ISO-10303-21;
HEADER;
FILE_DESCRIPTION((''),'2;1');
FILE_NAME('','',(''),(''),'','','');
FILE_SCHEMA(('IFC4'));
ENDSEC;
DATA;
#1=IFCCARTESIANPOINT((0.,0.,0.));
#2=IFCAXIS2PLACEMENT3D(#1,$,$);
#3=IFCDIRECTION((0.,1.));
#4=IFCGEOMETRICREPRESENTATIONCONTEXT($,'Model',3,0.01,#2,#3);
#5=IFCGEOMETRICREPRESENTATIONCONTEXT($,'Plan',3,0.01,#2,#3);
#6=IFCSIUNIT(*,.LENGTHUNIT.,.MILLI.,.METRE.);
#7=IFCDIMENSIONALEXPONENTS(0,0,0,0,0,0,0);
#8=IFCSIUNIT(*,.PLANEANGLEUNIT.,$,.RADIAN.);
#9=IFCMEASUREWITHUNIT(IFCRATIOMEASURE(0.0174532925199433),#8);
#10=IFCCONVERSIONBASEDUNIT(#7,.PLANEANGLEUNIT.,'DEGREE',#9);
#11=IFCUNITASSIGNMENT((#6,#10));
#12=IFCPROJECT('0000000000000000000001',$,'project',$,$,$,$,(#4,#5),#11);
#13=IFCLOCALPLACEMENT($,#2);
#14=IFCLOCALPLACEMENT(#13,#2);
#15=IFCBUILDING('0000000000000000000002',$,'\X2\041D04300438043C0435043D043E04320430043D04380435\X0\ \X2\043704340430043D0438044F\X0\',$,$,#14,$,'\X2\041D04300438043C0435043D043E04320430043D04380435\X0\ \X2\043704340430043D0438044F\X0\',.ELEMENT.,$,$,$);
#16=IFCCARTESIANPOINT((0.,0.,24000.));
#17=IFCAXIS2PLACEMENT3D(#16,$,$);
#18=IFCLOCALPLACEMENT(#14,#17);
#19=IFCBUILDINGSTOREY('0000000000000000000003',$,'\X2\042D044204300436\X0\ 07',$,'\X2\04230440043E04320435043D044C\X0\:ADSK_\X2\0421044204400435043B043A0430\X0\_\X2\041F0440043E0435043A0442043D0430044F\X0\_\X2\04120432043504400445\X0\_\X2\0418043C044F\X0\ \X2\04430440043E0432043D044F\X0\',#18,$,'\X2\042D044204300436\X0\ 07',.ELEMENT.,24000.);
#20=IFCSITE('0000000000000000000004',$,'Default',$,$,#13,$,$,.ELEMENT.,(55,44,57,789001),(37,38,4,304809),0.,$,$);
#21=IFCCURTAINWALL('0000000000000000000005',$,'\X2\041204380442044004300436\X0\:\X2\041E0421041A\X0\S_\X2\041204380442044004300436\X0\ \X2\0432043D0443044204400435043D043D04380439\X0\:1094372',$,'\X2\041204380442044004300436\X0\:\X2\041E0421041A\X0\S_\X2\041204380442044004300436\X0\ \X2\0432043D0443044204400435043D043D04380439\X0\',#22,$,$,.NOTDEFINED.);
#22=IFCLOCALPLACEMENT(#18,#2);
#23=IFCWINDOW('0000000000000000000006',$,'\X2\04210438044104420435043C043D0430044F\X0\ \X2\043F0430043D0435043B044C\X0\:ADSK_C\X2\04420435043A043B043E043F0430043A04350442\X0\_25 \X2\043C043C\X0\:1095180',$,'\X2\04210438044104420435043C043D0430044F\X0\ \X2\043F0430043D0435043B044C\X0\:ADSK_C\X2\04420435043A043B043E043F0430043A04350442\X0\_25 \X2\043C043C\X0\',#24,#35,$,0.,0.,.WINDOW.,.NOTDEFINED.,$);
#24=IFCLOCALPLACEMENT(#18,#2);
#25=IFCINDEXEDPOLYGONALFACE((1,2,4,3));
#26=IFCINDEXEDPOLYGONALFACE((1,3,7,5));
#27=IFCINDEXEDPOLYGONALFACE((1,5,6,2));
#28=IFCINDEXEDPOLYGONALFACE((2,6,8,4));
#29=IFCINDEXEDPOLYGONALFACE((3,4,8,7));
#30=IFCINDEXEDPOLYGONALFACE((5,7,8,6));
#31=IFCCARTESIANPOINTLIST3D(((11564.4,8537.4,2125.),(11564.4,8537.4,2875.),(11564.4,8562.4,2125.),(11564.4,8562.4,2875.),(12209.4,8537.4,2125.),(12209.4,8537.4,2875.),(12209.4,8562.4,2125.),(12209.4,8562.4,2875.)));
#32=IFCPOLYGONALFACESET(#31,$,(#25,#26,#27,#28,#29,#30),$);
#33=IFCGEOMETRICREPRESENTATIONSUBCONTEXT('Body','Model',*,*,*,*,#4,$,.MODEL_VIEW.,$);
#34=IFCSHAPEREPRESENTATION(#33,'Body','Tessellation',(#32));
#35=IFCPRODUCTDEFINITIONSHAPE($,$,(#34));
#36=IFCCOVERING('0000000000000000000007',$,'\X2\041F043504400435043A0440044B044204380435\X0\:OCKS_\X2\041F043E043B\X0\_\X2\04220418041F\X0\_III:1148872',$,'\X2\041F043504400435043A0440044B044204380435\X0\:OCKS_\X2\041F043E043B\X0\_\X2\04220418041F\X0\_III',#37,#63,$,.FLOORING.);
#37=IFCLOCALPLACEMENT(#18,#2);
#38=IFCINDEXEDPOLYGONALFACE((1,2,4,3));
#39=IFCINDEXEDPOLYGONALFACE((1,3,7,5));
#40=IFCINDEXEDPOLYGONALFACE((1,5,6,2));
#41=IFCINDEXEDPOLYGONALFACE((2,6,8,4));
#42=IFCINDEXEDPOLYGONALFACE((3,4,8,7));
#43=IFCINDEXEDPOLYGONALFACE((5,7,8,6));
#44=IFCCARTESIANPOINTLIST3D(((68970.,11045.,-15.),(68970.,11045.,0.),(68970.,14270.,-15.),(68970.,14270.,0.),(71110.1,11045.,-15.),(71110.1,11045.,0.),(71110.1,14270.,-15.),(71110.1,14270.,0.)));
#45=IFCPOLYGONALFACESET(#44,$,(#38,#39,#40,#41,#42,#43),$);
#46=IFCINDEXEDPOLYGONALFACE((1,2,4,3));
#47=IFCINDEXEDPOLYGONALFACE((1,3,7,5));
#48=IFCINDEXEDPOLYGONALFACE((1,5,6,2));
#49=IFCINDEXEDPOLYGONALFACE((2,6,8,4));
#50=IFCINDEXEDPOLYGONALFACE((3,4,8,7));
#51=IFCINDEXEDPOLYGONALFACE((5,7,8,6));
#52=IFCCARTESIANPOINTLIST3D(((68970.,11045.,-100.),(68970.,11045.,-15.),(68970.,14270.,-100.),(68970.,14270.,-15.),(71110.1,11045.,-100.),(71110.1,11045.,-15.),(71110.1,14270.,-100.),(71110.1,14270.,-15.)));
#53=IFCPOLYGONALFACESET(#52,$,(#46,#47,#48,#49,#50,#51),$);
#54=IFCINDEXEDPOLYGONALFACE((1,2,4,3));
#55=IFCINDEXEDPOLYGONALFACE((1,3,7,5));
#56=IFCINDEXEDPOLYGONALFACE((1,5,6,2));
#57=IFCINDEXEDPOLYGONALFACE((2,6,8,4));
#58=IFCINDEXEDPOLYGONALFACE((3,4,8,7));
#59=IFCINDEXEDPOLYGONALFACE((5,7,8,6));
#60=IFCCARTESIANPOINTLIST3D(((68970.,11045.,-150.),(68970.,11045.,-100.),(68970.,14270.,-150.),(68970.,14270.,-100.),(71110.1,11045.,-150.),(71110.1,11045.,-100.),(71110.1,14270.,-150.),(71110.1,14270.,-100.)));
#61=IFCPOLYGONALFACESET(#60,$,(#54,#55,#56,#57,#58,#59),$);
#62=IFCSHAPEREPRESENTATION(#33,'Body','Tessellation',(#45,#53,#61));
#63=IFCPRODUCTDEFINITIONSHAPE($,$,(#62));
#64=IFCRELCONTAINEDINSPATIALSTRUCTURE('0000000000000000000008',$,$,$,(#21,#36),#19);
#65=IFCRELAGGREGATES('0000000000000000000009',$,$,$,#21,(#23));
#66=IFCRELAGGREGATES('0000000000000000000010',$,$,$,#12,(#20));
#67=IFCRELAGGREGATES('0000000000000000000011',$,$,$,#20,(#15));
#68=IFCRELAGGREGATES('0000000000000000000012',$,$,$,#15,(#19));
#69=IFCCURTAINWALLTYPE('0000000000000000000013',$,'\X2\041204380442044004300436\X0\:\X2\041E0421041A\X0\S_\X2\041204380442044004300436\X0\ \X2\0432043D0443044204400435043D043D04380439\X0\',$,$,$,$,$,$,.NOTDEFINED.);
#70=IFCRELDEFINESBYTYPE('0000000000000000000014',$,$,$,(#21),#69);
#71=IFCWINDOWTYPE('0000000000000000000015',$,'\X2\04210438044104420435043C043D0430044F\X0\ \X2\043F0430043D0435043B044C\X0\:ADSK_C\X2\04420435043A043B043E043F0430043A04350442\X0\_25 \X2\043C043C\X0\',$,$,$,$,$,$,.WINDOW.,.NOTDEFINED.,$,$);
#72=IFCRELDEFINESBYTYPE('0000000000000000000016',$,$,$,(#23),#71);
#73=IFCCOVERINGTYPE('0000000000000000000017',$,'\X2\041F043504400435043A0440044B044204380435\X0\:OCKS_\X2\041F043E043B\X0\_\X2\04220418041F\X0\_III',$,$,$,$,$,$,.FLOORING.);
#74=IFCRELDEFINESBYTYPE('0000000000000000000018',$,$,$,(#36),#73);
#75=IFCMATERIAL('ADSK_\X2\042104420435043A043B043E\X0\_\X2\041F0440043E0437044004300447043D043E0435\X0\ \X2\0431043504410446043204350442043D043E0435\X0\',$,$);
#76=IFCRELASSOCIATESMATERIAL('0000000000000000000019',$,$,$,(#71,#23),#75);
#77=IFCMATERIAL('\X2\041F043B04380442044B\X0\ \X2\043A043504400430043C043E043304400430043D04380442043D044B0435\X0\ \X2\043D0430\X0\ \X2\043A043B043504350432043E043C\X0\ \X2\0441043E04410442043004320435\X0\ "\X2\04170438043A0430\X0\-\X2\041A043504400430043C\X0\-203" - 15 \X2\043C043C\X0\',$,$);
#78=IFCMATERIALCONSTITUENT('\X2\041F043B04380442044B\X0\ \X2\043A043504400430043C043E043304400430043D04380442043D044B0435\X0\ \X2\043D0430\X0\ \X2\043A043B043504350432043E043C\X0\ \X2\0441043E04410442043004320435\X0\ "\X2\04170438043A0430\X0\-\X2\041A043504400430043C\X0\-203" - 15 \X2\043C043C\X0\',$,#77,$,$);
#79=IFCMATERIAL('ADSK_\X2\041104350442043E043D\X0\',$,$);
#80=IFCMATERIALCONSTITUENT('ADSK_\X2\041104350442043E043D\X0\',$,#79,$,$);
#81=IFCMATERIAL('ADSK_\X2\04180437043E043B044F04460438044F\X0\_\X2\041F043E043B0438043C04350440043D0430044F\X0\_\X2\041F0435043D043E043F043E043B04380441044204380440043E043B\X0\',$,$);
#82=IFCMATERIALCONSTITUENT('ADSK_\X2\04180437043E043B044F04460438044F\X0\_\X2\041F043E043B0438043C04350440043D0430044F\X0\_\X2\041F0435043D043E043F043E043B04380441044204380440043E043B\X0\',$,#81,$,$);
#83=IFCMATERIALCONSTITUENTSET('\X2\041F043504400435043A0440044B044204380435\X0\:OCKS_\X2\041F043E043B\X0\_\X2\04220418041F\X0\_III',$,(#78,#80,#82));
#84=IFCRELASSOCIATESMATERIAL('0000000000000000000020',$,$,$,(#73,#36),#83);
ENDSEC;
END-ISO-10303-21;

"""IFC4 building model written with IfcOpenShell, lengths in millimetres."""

from ifc_helpers import new_model, entity, si_unit, converted_unit, direction, frame, origin, place, context, subcontext, project, spatial, indexed_curve, outline, extrude, source, transform, mapped, material, constituent, constituent_set, type_object, type_shapes, element, aggregate, save


model = new_model("IFC4")

# Units and contexts
model_context = context("Model", 3, precision=0.01, world=origin(), true_north=direction((0.0, 1.0)))
plan_context = context("Plan", 3, precision=0.01, world=origin(), true_north=direction((0.0, 1.0)))
body_context = subcontext(model_context, "Body", "Model", "MODEL_VIEW")
ifc_project = project(units=[si_unit("LENGTHUNIT", "METRE", prefix="MILLI"), converted_unit("PLANEANGLEUNIT", "DEGREE", entity("IfcRatioMeasure", 0.0174532925199433), si_unit("PLANEANGLEUNIT", "RADIAN"), dimensions=[0, 0, 0, 0, 0, 0, 0])], contexts=[model_context, plan_context])

# Site, building, storey
site_placement = place(None, frame((0.0, 0.0, 0.0)))
site = spatial("IfcSite", under=ifc_project, at=site_placement, Name="Default", CompositionType="ELEMENT", RefLatitude=(55, 44, 57, 789001), RefLongitude=(37, 38, 4, 304809), RefElevation=0.0)
building_placement = place(site_placement, origin())
building = spatial("IfcBuilding", under=site, at=building_placement, Name="Наименование здания", LongName="Наименование здания", CompositionType="ELEMENT")
storey_placement = place(building_placement, frame((0.0, 0.0, 24000.0)))
storey = spatial("IfcBuildingStorey", under=building, at=storey_placement, Name="Этаж 07", ObjectType="Уровень:ADSK_Стрелка_Проектная_Вверх_Имя уровня", LongName="Этаж 07", CompositionType="ELEMENT", Elevation=24000.0)

# Curtain wall
curtain_wall_type = type_object("IfcCurtainWallType", Name="Витраж:ОСКS_Витраж внутренний", PredefinedType="NOTDEFINED")
curtain_wall_placement = place(storey_placement, frame((0.0, 0.0, -24000.0)))
curtain_wall = element("IfcCurtainWall", 1, at=curtain_wall_placement, inside=storey, type_object=curtain_wall_type, Name="Витраж:ОСКS_Витраж внутренний:1094372", ObjectType="Витраж:ОСКS_Витраж внутренний", PredefinedType="NOTDEFINED")

# Window
ifc_material_1 = material(Name="ADSK_Стекло_Прозрачное бесцветное")
window_type_1 = type_object("IfcWindowType", Name="Системная панель:ADSK_Cтеклопакет_25 мм", PartitioningType="NOTDEFINED", PredefinedType="WINDOW", material=ifc_material_1)
shared_shape_1 = source(origin(), body_context, "Body", "SweptSolid", [
    extrude(outline(indexed_curve([(-12.5, -322.5), (12.5, -322.5), (12.5, 322.5), (-12.5, 322.5), (-12.5, -322.5)], self_intersect=False)), frame((0.0, 0.0, 0.0), z_axis=(0.0, 0.0, 1.0), x_axis=(0.0, 1.0, 0.0)), (0.0, 0.0, 1.0), 750.0),
])
type_shapes(window_type_1, [shared_shape_1])
window_1_placement = place(curtain_wall_placement, frame((11886.9, 8549.9, 26125.0)))
window_1 = element("IfcWindow", 2, at=window_1_placement, type_object=window_type_1, material=ifc_material_1, Name="Системная панель:ADSK_Cтеклопакет_25 мм:1095180", ObjectType="Системная панель:ADSK_Cтеклопакет_25 мм", OverallHeight=0.0, OverallWidth=0.0, PartitioningType="NOTDEFINED", PredefinedType="WINDOW", context=body_context, shape_type="MappedRepresentation", body=[
    mapped(shared_shape_1, transform((0.0, 0.0, 0.0), scale=1.0)),
])
aggregate(curtain_wall, [window_1])

# Covering
ifc_material_2 = material(Name="ADSK_Бетон")
ifc_material_3 = material(Name="ADSK_Изоляция_Полимерная_Пенополистирол")
ifc_material_4 = material(Name="Плиты керамогранитные на клеевом составе \"Зика-Керам-203\" - 15 мм")
ifc_constituent_1 = constituent(ifc_material_4, Name="Плиты керамогранитные на клеевом составе \"Зика-Керам-203\" - 15 мм")
ifc_constituent_2 = constituent(ifc_material_2, Name="ADSK_Бетон")
ifc_constituent_3 = constituent(ifc_material_3, Name="ADSK_Изоляция_Полимерная_Пенополистирол")
ifc_constituent_set_1 = constituent_set(constituents=[ifc_constituent_1, ifc_constituent_2, ifc_constituent_3], Name="Перекрытие:OCKS_Пол_ТИП_III")
covering_type_1 = type_object("IfcCoveringType", Name="Перекрытие:OCKS_Пол_ТИП_III", PredefinedType="FLOORING", material=ifc_constituent_set_1)
covering_1_placement = place(storey_placement, origin())
element("IfcCovering", 3, at=covering_1_placement, inside=storey, type_object=covering_type_1, material=ifc_constituent_set_1, Name="Перекрытие:OCKS_Пол_ТИП_III:1148872", ObjectType="Перекрытие:OCKS_Пол_ТИП_III", PredefinedType="FLOORING", context=body_context, shape_type="SweptSolid", body=[
    extrude(outline(indexed_curve([(-1070.0, -1612.5), (1070.0, -1612.5), (1070.0, 1612.5), (-1070.0, 1612.5), (-1070.0, -1612.5)], self_intersect=False)), frame((70040.0, 12657.5, -15.0), z_axis=(0.0, 0.0, 1.0), x_axis=(-1.0, 0.0, 0.0)), (0.0, 0.0, 1.0), 15.0),
    extrude(outline(indexed_curve([(-1070.0, -1612.5), (1070.0, -1612.5), (1070.0, 1612.5), (-1070.0, 1612.5), (-1070.0, -1612.5)], self_intersect=False)), frame((70040.0, 12657.5, -100.0), z_axis=(0.0, 0.0, 1.0), x_axis=(-1.0, 0.0, 0.0)), (0.0, 0.0, 1.0), 85.0),
    extrude(outline(indexed_curve([(-1070.0, -1612.5), (1070.0, -1612.5), (1070.0, 1612.5), (-1070.0, 1612.5), (-1070.0, -1612.5)], self_intersect=False)), frame((70040.0, 12657.5, -150.0), z_axis=(0.0, 0.0, 1.0), x_axis=(-1.0, 0.0, 0.0)), (0.0, 0.0, 1.0), 50.0),
])

save(model, "model.ifc")
